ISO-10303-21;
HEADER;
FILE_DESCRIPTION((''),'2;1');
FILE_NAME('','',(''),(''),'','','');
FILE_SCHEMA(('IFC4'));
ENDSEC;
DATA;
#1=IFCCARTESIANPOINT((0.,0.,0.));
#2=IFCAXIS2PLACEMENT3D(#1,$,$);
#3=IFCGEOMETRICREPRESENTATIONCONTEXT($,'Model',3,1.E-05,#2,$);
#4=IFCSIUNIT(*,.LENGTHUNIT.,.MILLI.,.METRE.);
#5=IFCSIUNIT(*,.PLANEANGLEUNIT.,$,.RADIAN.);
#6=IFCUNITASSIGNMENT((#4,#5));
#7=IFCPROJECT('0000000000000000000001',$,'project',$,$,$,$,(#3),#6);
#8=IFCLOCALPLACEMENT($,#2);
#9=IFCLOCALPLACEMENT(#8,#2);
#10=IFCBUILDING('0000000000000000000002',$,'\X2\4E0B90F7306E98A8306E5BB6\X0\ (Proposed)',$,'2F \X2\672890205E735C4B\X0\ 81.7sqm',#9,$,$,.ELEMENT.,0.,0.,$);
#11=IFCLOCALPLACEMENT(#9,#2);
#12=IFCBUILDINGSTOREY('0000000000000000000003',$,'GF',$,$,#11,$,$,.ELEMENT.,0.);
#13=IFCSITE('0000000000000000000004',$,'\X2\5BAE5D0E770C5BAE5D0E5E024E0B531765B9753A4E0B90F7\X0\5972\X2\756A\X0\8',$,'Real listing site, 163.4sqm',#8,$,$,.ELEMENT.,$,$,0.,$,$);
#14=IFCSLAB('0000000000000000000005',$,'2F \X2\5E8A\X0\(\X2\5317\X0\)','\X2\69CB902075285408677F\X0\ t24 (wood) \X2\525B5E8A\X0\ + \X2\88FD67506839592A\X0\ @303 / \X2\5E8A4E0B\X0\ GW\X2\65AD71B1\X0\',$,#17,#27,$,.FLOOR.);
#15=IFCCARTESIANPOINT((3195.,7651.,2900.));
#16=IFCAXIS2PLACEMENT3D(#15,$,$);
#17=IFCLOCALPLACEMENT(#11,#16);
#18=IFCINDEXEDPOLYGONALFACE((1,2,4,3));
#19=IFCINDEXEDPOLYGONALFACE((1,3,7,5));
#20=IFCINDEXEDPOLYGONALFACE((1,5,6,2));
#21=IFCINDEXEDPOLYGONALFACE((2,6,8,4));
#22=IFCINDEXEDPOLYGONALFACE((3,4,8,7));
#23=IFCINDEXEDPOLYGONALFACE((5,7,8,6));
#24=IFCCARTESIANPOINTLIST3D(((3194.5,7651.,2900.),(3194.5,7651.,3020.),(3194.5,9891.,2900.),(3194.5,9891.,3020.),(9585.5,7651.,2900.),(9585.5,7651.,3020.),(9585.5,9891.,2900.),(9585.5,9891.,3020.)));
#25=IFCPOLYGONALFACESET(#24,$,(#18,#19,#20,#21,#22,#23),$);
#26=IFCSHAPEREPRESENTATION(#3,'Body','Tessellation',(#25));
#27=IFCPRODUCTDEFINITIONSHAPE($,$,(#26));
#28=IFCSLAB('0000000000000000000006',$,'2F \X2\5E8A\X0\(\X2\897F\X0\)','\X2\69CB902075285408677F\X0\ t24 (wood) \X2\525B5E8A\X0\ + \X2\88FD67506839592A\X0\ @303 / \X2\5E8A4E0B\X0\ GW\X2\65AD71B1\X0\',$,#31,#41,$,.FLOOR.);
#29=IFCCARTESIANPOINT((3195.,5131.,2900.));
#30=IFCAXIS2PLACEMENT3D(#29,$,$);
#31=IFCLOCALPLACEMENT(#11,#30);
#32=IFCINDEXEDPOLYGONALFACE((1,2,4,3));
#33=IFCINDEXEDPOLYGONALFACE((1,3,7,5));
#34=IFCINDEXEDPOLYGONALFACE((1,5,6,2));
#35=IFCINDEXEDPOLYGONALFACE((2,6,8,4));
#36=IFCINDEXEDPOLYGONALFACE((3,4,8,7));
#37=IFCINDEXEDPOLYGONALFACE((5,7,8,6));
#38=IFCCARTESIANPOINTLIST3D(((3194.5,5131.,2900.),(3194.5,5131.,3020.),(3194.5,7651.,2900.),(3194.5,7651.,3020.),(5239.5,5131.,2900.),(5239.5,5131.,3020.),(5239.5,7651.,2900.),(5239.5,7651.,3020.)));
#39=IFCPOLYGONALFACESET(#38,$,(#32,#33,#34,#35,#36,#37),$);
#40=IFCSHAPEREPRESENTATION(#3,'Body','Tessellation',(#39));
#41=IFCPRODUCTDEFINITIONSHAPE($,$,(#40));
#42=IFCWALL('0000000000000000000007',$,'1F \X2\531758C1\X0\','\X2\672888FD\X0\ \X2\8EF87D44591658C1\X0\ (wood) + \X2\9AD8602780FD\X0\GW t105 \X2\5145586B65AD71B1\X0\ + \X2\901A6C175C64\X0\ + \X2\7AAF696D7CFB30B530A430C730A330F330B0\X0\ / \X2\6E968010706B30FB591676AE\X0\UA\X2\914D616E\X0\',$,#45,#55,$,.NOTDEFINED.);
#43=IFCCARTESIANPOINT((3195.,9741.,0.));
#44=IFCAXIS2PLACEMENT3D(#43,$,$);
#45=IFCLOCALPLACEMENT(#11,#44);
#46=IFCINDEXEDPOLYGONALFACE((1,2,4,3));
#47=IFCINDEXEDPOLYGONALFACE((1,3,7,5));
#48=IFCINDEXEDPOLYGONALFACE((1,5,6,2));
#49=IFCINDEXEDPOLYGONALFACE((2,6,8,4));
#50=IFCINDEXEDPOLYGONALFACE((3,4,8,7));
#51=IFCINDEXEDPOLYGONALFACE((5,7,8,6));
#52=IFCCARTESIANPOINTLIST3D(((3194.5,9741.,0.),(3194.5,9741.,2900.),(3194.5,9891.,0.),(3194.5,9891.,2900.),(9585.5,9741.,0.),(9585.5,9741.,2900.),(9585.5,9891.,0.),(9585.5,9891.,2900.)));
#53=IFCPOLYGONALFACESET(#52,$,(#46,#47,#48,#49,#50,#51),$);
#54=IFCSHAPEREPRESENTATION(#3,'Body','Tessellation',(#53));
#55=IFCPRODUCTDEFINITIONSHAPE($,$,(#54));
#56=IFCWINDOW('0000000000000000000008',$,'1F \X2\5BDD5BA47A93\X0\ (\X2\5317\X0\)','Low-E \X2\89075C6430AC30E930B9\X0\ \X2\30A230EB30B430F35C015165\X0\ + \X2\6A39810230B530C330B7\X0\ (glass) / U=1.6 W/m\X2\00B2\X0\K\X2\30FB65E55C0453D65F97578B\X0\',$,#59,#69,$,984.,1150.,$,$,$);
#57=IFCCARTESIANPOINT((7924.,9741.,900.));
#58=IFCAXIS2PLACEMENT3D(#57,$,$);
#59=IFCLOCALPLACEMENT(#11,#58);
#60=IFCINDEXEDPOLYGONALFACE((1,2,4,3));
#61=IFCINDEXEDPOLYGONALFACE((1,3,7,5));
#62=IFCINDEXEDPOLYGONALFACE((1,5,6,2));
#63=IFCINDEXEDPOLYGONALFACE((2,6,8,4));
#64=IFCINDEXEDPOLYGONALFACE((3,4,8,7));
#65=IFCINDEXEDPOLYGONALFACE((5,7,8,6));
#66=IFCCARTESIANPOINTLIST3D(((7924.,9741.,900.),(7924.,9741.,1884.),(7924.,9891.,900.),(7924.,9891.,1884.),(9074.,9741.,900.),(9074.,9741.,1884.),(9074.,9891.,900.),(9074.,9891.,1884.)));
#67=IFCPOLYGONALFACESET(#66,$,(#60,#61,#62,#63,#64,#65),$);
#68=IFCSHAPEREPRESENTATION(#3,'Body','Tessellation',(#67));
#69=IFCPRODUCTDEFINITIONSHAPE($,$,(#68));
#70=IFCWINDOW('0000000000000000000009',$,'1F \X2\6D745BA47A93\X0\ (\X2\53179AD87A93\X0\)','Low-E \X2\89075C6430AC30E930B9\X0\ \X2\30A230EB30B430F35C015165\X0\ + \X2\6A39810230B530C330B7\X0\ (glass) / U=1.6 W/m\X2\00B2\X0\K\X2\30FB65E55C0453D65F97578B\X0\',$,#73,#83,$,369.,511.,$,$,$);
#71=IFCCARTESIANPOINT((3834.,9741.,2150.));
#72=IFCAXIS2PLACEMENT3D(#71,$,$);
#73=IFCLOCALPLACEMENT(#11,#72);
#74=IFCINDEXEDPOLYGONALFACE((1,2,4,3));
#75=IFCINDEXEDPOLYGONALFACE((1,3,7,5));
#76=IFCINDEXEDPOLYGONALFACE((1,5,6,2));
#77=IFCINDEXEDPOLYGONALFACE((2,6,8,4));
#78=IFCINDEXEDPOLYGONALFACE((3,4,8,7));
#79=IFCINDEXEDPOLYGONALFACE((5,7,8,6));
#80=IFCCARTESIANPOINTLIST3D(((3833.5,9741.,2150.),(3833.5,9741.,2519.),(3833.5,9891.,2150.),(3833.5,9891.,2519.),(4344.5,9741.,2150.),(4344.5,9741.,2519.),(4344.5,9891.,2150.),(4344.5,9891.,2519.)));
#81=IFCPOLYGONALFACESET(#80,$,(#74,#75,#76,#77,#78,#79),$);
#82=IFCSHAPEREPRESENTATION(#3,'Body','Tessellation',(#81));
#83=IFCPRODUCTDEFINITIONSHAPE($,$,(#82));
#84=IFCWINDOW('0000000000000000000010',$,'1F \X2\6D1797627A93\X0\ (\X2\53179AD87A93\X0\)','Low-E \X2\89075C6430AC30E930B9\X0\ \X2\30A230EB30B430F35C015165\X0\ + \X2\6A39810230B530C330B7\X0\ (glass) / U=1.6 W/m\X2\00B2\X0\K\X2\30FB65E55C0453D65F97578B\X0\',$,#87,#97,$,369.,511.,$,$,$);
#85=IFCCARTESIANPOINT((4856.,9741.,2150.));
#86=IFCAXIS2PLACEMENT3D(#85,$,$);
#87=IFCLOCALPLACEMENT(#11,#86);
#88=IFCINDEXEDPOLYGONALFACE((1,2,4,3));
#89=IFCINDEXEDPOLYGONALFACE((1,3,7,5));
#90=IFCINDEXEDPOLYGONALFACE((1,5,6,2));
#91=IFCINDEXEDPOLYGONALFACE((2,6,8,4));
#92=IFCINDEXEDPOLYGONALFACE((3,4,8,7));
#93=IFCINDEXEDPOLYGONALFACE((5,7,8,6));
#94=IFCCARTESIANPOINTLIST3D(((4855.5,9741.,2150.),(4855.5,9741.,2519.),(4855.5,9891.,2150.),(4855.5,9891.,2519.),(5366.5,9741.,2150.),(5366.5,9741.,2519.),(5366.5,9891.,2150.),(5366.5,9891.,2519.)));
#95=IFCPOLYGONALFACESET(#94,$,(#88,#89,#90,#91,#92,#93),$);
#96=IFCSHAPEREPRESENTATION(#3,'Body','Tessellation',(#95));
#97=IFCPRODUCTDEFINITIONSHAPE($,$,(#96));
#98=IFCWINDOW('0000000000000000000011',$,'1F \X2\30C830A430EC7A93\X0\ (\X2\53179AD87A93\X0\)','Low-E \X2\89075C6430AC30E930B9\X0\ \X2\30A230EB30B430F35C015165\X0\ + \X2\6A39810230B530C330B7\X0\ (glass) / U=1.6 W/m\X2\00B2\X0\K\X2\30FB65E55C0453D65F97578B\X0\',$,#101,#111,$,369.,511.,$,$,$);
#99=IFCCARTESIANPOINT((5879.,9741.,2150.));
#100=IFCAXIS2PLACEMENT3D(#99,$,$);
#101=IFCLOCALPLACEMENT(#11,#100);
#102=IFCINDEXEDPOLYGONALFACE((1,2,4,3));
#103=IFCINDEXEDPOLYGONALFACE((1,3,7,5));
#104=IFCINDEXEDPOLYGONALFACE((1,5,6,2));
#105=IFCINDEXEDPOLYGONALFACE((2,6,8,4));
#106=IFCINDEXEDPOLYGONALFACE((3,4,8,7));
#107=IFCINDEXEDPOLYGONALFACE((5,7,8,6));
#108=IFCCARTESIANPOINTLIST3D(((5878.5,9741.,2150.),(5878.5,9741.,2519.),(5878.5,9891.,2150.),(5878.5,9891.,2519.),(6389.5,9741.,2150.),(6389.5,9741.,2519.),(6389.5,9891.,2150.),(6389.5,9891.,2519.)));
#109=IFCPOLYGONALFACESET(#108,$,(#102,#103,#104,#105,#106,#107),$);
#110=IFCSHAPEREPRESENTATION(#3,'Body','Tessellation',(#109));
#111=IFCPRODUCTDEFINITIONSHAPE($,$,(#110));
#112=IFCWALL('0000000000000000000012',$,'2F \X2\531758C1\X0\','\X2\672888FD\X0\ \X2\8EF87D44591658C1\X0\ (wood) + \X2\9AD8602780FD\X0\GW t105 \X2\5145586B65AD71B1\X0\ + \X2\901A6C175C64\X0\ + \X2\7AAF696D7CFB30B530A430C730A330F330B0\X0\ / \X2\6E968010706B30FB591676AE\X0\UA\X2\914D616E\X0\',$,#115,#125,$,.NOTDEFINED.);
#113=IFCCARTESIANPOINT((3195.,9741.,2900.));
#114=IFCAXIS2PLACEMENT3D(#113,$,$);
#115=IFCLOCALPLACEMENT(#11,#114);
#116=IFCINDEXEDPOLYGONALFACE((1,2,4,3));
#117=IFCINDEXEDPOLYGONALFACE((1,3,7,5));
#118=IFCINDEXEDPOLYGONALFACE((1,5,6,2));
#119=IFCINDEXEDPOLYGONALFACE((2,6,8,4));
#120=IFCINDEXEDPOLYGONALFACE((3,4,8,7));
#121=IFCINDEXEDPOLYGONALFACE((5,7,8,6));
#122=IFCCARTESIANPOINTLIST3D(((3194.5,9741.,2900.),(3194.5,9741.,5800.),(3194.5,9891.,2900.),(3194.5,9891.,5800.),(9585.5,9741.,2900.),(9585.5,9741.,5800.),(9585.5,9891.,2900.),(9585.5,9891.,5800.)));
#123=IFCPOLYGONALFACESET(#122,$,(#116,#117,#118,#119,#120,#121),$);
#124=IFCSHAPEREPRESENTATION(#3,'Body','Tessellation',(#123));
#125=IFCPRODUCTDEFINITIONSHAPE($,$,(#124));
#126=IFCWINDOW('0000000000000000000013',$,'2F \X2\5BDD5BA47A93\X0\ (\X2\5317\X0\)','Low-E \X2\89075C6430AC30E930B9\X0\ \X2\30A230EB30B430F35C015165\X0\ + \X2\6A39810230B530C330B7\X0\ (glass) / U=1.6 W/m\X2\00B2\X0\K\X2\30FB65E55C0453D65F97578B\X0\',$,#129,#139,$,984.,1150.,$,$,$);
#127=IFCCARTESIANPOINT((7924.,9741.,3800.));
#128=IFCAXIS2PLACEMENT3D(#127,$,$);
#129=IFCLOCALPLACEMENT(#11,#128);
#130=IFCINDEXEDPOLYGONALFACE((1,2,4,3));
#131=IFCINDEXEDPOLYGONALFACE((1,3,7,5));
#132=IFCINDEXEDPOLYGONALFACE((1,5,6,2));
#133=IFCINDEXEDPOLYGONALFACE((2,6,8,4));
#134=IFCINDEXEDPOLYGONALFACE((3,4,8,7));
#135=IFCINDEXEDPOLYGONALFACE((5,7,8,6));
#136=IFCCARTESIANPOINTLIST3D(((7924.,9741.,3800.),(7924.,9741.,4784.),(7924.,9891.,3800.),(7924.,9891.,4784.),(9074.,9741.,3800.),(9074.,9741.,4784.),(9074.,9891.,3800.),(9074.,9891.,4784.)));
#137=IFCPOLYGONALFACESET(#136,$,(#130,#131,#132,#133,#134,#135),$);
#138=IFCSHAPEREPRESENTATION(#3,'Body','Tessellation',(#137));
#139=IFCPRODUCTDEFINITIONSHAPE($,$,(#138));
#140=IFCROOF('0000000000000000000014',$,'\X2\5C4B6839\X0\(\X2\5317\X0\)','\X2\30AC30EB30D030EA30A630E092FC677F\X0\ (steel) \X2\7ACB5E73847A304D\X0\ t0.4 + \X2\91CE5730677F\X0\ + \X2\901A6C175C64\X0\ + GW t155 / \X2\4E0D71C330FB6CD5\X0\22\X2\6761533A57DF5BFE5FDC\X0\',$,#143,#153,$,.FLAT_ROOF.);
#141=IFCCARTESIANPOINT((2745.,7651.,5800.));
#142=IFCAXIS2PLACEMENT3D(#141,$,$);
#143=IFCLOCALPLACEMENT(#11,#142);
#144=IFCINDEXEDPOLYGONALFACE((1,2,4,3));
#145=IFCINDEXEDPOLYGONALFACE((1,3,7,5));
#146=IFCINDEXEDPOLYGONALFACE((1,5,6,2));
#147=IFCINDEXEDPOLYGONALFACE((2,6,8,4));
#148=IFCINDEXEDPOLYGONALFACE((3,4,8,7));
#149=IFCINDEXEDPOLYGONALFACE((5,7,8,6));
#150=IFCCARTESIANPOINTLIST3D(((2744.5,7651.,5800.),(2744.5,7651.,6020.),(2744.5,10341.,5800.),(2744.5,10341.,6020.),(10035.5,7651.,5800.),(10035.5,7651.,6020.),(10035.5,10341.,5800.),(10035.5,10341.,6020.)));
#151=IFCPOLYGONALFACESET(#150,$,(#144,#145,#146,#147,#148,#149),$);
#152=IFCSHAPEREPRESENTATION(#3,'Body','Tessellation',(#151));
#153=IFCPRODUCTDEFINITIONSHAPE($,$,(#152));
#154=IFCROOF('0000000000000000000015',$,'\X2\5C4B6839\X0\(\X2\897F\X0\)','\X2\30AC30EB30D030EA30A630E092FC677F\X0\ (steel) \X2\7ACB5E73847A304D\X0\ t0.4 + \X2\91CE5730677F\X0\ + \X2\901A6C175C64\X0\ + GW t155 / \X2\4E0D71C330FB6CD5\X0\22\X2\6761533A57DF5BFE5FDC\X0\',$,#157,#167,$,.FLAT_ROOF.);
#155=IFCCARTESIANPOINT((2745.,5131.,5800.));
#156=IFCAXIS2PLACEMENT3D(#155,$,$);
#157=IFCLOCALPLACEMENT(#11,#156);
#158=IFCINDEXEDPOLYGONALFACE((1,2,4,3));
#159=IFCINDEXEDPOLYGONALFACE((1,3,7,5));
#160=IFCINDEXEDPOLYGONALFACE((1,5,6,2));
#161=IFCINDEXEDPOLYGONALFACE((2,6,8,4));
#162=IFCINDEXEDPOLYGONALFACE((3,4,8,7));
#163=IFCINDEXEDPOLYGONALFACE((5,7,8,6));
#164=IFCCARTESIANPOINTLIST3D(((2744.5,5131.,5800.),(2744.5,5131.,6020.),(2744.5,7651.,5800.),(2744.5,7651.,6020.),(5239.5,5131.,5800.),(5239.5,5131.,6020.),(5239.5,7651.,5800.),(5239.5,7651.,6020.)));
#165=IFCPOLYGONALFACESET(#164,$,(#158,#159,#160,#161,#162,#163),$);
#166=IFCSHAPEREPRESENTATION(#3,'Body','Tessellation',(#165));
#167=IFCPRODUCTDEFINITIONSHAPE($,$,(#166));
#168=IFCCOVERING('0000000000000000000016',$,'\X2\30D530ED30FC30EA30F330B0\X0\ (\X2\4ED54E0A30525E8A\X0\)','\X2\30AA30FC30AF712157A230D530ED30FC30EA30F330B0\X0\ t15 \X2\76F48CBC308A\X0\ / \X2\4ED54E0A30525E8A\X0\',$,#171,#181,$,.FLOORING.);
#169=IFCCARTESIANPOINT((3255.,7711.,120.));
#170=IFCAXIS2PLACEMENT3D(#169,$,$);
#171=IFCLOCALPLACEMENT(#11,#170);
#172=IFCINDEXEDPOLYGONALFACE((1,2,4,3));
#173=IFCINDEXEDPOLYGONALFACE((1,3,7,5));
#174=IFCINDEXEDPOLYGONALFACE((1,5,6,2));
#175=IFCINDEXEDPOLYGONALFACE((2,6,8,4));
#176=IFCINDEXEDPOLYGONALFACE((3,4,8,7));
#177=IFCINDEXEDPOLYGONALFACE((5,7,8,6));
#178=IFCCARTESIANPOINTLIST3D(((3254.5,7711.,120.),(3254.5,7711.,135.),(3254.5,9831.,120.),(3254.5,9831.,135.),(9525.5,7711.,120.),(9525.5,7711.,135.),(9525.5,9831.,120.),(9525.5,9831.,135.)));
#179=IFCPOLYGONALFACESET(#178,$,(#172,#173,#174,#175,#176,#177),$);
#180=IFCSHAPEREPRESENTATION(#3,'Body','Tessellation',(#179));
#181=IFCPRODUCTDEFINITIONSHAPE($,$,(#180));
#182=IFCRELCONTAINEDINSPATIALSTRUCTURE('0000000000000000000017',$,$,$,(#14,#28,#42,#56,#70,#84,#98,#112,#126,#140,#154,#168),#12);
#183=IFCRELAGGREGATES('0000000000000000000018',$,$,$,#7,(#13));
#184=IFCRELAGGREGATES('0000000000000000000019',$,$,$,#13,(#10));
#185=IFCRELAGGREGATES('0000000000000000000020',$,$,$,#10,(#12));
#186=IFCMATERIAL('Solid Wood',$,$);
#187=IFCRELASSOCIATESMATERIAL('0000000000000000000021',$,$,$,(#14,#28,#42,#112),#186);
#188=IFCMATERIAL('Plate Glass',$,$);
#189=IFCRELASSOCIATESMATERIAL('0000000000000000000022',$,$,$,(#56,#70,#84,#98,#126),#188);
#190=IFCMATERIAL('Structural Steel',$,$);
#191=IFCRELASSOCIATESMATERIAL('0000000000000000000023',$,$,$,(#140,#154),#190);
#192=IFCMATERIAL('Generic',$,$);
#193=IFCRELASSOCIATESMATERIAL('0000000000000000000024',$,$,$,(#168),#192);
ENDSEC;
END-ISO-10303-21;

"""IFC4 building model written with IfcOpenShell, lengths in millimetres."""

from ifc_helpers import new_model, si_unit, frame, frame_2d, origin, place, context, project, spatial, rectangle, extrude, material, element, fill, save


model = new_model("IFC4")

# Units and contexts
model_context = context("Model", 3, precision=1e-05, world=origin())
ifc_project = project(units=[si_unit("LENGTHUNIT", "METRE", prefix="MILLI"), si_unit("PLANEANGLEUNIT", "RADIAN")], contexts=[model_context])

# Site, building, storey
site_placement = place(None, origin())
site = spatial("IfcSite", under=ifc_project, at=site_placement, Name="宮崎県宮崎市下北方町下郷5972番8", ObjectType="Real listing site, 163.4sqm", CompositionType="ELEMENT", RefElevation=0.0)
building_placement = place(site_placement, origin())
building = spatial("IfcBuilding", under=site, at=building_placement, Name="下郷の風の家 (Proposed)", ObjectType="2F 木造平屋 81.7sqm", CompositionType="ELEMENT", ElevationOfRefHeight=0.0, ElevationOfTerrain=0.0)
storey_placement = place(building_placement, origin())
storey = spatial("IfcBuildingStorey", under=building, at=storey_placement, Name="GF", CompositionType="ELEMENT", Elevation=0.0)

# Slabs
ifc_material_1 = material(Name="Solid Wood")
slab_1_placement = place(storey_placement, frame((3195.0, 7651.0, 2900.0)))
element("IfcSlab", 1, at=slab_1_placement, inside=storey, material=ifc_material_1, Name="2F 床(北)", Description="構造用合板 t24 (wood) 剛床 + 製材根太 @303 / 床下 GW断熱", PredefinedType="FLOOR", context=model_context, shape_type="SweptSolid", body=[
    extrude(rectangle(XDim=6391.0, YDim=2240.0, at=frame_2d((3195.0, 1120.0))), frame((3195.0, 7651.0, 2900.0)), (0.0, 0.0, 1.0), 120.0),
])
slab_2_placement = place(storey_placement, frame((3195.0, 5131.0, 2900.0)))
element("IfcSlab", 2, at=slab_2_placement, inside=storey, material=ifc_material_1, Name="2F 床(西)", Description="構造用合板 t24 (wood) 剛床 + 製材根太 @303 / 床下 GW断熱", PredefinedType="FLOOR", context=model_context, shape_type="SweptSolid", body=[
    extrude(rectangle(XDim=2045.0, YDim=2520.0, at=frame_2d((1022.0, 1260.0))), frame((3195.0, 5131.0, 2900.0)), (0.0, 0.0, 1.0), 120.0),
])

# Wall, openings, windows
wall_1_placement = place(storey_placement, frame((3195.0, 9741.0, 0.0)))
wall_1 = element("IfcWall", 3, at=wall_1_placement, inside=storey, material=ifc_material_1, Name="1F 北壁", Description="木製 軸組外壁 (wood) + 高性能GW t105 充填断熱 + 通気層 + 窯業系サイディング / 準耐火・外皮UA配慮", PredefinedType="NOTDEFINED", context=model_context, shape_type="SweptSolid", body=[
    extrude(rectangle(XDim=6391.0, YDim=150.0, at=frame_2d((3195.0, 75.0))), frame((3195.0, 9741.0, 0.0)), (0.0, 0.0, 1.0), 2900.0),
])
opening_1_placement = place(storey_placement, frame((7924.0, 9741.0, 900.0)))
opening_1 = element("IfcOpeningElement", 4, at=opening_1_placement, cuts=wall_1, PredefinedType="NOTDEFINED", context=model_context, shape_type="SweptSolid", body=[
    extrude(rectangle(XDim=1150.0, YDim=150.0, at=frame_2d((575.0, 75.0))), frame((7924.0, 9741.0, 900.0)), (0.0, 0.0, 1.0), 984.0),
])
opening_2_placement = place(storey_placement, frame((3834.0, 9741.0, 2150.0)))
opening_2 = element("IfcOpeningElement", 5, at=opening_2_placement, cuts=wall_1, PredefinedType="NOTDEFINED", context=model_context, shape_type="SweptSolid", body=[
    extrude(rectangle(XDim=511.0, YDim=150.0, at=frame_2d((255.0, 75.0))), frame((3834.0, 9741.0, 2150.0)), (0.0, 0.0, 1.0), 369.0),
])
opening_3_placement = place(storey_placement, frame((4856.0, 9741.0, 2150.0)))
opening_3 = element("IfcOpeningElement", 6, at=opening_3_placement, cuts=wall_1, PredefinedType="NOTDEFINED", context=model_context, shape_type="SweptSolid", body=[
    extrude(rectangle(XDim=511.0, YDim=150.0, at=frame_2d((255.0, 75.0))), frame((4856.0, 9741.0, 2150.0)), (0.0, 0.0, 1.0), 369.0),
])
opening_4_placement = place(storey_placement, frame((5879.0, 9741.0, 2150.0)))
opening_4 = element("IfcOpeningElement", 7, at=opening_4_placement, cuts=wall_1, PredefinedType="NOTDEFINED", context=model_context, shape_type="SweptSolid", body=[
    extrude(rectangle(XDim=511.0, YDim=150.0, at=frame_2d((255.0, 75.0))), frame((5879.0, 9741.0, 2150.0)), (0.0, 0.0, 1.0), 369.0),
])
ifc_material_2 = material(Name="Plate Glass")
window_1_placement = place(storey_placement, frame((7924.0, 9741.0, 900.0)))
window_1 = element("IfcWindow", 8, at=window_1_placement, inside=storey, material=ifc_material_2, Name="1F 寝室窓 (北)", Description="Low-E 複層ガラス アルゴン封入 + 樹脂サッシ (glass) / U=1.6 W/m²K・日射取得型", OverallHeight=984.0, OverallWidth=1150.0, context=model_context, shape_type="SweptSolid", body=[
    extrude(rectangle(XDim=1150.0, YDim=150.0, at=frame_2d((575.0, 75.0))), frame((7924.0, 9741.0, 900.0)), (0.0, 0.0, 1.0), 984.0),
])
fill(opening_1, window_1)
window_2_placement = place(storey_placement, frame((3834.0, 9741.0, 2150.0)))
window_2 = element("IfcWindow", 9, at=window_2_placement, inside=storey, material=ifc_material_2, Name="1F 浴室窓 (北高窓)", Description="Low-E 複層ガラス アルゴン封入 + 樹脂サッシ (glass) / U=1.6 W/m²K・日射取得型", OverallHeight=369.0, OverallWidth=511.0, context=model_context, shape_type="SweptSolid", body=[
    extrude(rectangle(XDim=511.0, YDim=150.0, at=frame_2d((255.0, 75.0))), frame((3834.0, 9741.0, 2150.0)), (0.0, 0.0, 1.0), 369.0),
])
fill(opening_2, window_2)
window_3_placement = place(storey_placement, frame((4856.0, 9741.0, 2150.0)))
window_3 = element("IfcWindow", 10, at=window_3_placement, inside=storey, material=ifc_material_2, Name="1F 洗面窓 (北高窓)", Description="Low-E 複層ガラス アルゴン封入 + 樹脂サッシ (glass) / U=1.6 W/m²K・日射取得型", OverallHeight=369.0, OverallWidth=511.0, context=model_context, shape_type="SweptSolid", body=[
    extrude(rectangle(XDim=511.0, YDim=150.0, at=frame_2d((255.0, 75.0))), frame((4856.0, 9741.0, 2150.0)), (0.0, 0.0, 1.0), 369.0),
])
fill(opening_3, window_3)
window_4_placement = place(storey_placement, frame((5879.0, 9741.0, 2150.0)))
window_4 = element("IfcWindow", 11, at=window_4_placement, inside=storey, material=ifc_material_2, Name="1F トイレ窓 (北高窓)", Description="Low-E 複層ガラス アルゴン封入 + 樹脂サッシ (glass) / U=1.6 W/m²K・日射取得型", OverallHeight=369.0, OverallWidth=511.0, context=model_context, shape_type="SweptSolid", body=[
    extrude(rectangle(XDim=511.0, YDim=150.0, at=frame_2d((255.0, 75.0))), frame((5879.0, 9741.0, 2150.0)), (0.0, 0.0, 1.0), 369.0),
])
fill(opening_4, window_4)

# Wall, opening, window
wall_2_placement = place(storey_placement, frame((3195.0, 9741.0, 2900.0)))
wall_2 = element("IfcWall", 12, at=wall_2_placement, inside=storey, material=ifc_material_1, Name="2F 北壁", Description="木製 軸組外壁 (wood) + 高性能GW t105 充填断熱 + 通気層 + 窯業系サイディング / 準耐火・外皮UA配慮", PredefinedType="NOTDEFINED", context=model_context, shape_type="SweptSolid", body=[
    extrude(rectangle(XDim=6391.0, YDim=150.0, at=frame_2d((3195.0, 75.0))), frame((3195.0, 9741.0, 2900.0)), (0.0, 0.0, 1.0), 2900.0),
])
opening_5_placement = place(storey_placement, frame((7924.0, 9741.0, 3800.0)))
opening_5 = element("IfcOpeningElement", 13, at=opening_5_placement, cuts=wall_2, PredefinedType="NOTDEFINED", context=model_context, shape_type="SweptSolid", body=[
    extrude(rectangle(XDim=1150.0, YDim=150.0, at=frame_2d((575.0, 75.0))), frame((7924.0, 9741.0, 3800.0)), (0.0, 0.0, 1.0), 984.0),
])
window_5_placement = place(storey_placement, frame((7924.0, 9741.0, 3800.0)))
window_5 = element("IfcWindow", 14, at=window_5_placement, inside=storey, material=ifc_material_2, Name="2F 寝室窓 (北)", Description="Low-E 複層ガラス アルゴン封入 + 樹脂サッシ (glass) / U=1.6 W/m²K・日射取得型", OverallHeight=984.0, OverallWidth=1150.0, context=model_context, shape_type="SweptSolid", body=[
    extrude(rectangle(XDim=1150.0, YDim=150.0, at=frame_2d((575.0, 75.0))), frame((7924.0, 9741.0, 3800.0)), (0.0, 0.0, 1.0), 984.0),
])
fill(opening_5, window_5)

# Roofs
ifc_material_3 = material(Name="Structural Steel")
for number, where, name in (
    (15, (2745.0, 7651.0, 5800.0), "屋根(北)"),
):
    element("IfcRoof", number, at=place(storey_placement, frame(where)), inside=storey, material=ifc_material_3, Name=name, Description="ガルバリウム鋼板 (steel) 立平葺き t0.4 + 野地板 + 通気層 + GW t155 / 不燃・法22条区域対応", PredefinedType="FLAT_ROOF", context=model_context, shape_type="SweptSolid", body=[
        extrude(rectangle(XDim=7291.0, YDim=2690.0, at=frame_2d((3645.0, 1345.0))), frame((2745.0, 7651.0, 5800.0)), (0.0, 0.0, 1.0), 220.0),
    ])
roof_placement = place(storey_placement, frame((2745.0, 5131.0, 5800.0)))
element("IfcRoof", 16, at=roof_placement, inside=storey, material=ifc_material_3, Name="屋根(西)", Description="ガルバリウム鋼板 (steel) 立平葺き t0.4 + 野地板 + 通気層 + GW t155 / 不燃・法22条区域対応", PredefinedType="FLAT_ROOF", context=model_context, shape_type="SweptSolid", body=[
    extrude(rectangle(XDim=2495.0, YDim=2520.0, at=frame_2d((1247.0, 1260.0))), frame((2745.0, 5131.0, 5800.0)), (0.0, 0.0, 1.0), 220.0),
])

# Covering
ifc_material_4 = material(Name="Generic")
covering_1_placement = place(storey_placement, frame((3255.0, 7711.0, 120.0)))
element("IfcCovering", 17, at=covering_1_placement, inside=storey, material=ifc_material_4, Name="フローリング (仕上げ床)", Description="オーク無垢フローリング t15 直貼り / 仕上げ床", PredefinedType="FLOORING", context=model_context, shape_type="SweptSolid", body=[
    extrude(rectangle(XDim=6271.0, YDim=2120.0, at=frame_2d((3135.0, 1060.0))), frame((3255.0, 7711.0, 120.0)), (0.0, 0.0, 1.0), 15.0),
])

save(model, "model.ifc")
